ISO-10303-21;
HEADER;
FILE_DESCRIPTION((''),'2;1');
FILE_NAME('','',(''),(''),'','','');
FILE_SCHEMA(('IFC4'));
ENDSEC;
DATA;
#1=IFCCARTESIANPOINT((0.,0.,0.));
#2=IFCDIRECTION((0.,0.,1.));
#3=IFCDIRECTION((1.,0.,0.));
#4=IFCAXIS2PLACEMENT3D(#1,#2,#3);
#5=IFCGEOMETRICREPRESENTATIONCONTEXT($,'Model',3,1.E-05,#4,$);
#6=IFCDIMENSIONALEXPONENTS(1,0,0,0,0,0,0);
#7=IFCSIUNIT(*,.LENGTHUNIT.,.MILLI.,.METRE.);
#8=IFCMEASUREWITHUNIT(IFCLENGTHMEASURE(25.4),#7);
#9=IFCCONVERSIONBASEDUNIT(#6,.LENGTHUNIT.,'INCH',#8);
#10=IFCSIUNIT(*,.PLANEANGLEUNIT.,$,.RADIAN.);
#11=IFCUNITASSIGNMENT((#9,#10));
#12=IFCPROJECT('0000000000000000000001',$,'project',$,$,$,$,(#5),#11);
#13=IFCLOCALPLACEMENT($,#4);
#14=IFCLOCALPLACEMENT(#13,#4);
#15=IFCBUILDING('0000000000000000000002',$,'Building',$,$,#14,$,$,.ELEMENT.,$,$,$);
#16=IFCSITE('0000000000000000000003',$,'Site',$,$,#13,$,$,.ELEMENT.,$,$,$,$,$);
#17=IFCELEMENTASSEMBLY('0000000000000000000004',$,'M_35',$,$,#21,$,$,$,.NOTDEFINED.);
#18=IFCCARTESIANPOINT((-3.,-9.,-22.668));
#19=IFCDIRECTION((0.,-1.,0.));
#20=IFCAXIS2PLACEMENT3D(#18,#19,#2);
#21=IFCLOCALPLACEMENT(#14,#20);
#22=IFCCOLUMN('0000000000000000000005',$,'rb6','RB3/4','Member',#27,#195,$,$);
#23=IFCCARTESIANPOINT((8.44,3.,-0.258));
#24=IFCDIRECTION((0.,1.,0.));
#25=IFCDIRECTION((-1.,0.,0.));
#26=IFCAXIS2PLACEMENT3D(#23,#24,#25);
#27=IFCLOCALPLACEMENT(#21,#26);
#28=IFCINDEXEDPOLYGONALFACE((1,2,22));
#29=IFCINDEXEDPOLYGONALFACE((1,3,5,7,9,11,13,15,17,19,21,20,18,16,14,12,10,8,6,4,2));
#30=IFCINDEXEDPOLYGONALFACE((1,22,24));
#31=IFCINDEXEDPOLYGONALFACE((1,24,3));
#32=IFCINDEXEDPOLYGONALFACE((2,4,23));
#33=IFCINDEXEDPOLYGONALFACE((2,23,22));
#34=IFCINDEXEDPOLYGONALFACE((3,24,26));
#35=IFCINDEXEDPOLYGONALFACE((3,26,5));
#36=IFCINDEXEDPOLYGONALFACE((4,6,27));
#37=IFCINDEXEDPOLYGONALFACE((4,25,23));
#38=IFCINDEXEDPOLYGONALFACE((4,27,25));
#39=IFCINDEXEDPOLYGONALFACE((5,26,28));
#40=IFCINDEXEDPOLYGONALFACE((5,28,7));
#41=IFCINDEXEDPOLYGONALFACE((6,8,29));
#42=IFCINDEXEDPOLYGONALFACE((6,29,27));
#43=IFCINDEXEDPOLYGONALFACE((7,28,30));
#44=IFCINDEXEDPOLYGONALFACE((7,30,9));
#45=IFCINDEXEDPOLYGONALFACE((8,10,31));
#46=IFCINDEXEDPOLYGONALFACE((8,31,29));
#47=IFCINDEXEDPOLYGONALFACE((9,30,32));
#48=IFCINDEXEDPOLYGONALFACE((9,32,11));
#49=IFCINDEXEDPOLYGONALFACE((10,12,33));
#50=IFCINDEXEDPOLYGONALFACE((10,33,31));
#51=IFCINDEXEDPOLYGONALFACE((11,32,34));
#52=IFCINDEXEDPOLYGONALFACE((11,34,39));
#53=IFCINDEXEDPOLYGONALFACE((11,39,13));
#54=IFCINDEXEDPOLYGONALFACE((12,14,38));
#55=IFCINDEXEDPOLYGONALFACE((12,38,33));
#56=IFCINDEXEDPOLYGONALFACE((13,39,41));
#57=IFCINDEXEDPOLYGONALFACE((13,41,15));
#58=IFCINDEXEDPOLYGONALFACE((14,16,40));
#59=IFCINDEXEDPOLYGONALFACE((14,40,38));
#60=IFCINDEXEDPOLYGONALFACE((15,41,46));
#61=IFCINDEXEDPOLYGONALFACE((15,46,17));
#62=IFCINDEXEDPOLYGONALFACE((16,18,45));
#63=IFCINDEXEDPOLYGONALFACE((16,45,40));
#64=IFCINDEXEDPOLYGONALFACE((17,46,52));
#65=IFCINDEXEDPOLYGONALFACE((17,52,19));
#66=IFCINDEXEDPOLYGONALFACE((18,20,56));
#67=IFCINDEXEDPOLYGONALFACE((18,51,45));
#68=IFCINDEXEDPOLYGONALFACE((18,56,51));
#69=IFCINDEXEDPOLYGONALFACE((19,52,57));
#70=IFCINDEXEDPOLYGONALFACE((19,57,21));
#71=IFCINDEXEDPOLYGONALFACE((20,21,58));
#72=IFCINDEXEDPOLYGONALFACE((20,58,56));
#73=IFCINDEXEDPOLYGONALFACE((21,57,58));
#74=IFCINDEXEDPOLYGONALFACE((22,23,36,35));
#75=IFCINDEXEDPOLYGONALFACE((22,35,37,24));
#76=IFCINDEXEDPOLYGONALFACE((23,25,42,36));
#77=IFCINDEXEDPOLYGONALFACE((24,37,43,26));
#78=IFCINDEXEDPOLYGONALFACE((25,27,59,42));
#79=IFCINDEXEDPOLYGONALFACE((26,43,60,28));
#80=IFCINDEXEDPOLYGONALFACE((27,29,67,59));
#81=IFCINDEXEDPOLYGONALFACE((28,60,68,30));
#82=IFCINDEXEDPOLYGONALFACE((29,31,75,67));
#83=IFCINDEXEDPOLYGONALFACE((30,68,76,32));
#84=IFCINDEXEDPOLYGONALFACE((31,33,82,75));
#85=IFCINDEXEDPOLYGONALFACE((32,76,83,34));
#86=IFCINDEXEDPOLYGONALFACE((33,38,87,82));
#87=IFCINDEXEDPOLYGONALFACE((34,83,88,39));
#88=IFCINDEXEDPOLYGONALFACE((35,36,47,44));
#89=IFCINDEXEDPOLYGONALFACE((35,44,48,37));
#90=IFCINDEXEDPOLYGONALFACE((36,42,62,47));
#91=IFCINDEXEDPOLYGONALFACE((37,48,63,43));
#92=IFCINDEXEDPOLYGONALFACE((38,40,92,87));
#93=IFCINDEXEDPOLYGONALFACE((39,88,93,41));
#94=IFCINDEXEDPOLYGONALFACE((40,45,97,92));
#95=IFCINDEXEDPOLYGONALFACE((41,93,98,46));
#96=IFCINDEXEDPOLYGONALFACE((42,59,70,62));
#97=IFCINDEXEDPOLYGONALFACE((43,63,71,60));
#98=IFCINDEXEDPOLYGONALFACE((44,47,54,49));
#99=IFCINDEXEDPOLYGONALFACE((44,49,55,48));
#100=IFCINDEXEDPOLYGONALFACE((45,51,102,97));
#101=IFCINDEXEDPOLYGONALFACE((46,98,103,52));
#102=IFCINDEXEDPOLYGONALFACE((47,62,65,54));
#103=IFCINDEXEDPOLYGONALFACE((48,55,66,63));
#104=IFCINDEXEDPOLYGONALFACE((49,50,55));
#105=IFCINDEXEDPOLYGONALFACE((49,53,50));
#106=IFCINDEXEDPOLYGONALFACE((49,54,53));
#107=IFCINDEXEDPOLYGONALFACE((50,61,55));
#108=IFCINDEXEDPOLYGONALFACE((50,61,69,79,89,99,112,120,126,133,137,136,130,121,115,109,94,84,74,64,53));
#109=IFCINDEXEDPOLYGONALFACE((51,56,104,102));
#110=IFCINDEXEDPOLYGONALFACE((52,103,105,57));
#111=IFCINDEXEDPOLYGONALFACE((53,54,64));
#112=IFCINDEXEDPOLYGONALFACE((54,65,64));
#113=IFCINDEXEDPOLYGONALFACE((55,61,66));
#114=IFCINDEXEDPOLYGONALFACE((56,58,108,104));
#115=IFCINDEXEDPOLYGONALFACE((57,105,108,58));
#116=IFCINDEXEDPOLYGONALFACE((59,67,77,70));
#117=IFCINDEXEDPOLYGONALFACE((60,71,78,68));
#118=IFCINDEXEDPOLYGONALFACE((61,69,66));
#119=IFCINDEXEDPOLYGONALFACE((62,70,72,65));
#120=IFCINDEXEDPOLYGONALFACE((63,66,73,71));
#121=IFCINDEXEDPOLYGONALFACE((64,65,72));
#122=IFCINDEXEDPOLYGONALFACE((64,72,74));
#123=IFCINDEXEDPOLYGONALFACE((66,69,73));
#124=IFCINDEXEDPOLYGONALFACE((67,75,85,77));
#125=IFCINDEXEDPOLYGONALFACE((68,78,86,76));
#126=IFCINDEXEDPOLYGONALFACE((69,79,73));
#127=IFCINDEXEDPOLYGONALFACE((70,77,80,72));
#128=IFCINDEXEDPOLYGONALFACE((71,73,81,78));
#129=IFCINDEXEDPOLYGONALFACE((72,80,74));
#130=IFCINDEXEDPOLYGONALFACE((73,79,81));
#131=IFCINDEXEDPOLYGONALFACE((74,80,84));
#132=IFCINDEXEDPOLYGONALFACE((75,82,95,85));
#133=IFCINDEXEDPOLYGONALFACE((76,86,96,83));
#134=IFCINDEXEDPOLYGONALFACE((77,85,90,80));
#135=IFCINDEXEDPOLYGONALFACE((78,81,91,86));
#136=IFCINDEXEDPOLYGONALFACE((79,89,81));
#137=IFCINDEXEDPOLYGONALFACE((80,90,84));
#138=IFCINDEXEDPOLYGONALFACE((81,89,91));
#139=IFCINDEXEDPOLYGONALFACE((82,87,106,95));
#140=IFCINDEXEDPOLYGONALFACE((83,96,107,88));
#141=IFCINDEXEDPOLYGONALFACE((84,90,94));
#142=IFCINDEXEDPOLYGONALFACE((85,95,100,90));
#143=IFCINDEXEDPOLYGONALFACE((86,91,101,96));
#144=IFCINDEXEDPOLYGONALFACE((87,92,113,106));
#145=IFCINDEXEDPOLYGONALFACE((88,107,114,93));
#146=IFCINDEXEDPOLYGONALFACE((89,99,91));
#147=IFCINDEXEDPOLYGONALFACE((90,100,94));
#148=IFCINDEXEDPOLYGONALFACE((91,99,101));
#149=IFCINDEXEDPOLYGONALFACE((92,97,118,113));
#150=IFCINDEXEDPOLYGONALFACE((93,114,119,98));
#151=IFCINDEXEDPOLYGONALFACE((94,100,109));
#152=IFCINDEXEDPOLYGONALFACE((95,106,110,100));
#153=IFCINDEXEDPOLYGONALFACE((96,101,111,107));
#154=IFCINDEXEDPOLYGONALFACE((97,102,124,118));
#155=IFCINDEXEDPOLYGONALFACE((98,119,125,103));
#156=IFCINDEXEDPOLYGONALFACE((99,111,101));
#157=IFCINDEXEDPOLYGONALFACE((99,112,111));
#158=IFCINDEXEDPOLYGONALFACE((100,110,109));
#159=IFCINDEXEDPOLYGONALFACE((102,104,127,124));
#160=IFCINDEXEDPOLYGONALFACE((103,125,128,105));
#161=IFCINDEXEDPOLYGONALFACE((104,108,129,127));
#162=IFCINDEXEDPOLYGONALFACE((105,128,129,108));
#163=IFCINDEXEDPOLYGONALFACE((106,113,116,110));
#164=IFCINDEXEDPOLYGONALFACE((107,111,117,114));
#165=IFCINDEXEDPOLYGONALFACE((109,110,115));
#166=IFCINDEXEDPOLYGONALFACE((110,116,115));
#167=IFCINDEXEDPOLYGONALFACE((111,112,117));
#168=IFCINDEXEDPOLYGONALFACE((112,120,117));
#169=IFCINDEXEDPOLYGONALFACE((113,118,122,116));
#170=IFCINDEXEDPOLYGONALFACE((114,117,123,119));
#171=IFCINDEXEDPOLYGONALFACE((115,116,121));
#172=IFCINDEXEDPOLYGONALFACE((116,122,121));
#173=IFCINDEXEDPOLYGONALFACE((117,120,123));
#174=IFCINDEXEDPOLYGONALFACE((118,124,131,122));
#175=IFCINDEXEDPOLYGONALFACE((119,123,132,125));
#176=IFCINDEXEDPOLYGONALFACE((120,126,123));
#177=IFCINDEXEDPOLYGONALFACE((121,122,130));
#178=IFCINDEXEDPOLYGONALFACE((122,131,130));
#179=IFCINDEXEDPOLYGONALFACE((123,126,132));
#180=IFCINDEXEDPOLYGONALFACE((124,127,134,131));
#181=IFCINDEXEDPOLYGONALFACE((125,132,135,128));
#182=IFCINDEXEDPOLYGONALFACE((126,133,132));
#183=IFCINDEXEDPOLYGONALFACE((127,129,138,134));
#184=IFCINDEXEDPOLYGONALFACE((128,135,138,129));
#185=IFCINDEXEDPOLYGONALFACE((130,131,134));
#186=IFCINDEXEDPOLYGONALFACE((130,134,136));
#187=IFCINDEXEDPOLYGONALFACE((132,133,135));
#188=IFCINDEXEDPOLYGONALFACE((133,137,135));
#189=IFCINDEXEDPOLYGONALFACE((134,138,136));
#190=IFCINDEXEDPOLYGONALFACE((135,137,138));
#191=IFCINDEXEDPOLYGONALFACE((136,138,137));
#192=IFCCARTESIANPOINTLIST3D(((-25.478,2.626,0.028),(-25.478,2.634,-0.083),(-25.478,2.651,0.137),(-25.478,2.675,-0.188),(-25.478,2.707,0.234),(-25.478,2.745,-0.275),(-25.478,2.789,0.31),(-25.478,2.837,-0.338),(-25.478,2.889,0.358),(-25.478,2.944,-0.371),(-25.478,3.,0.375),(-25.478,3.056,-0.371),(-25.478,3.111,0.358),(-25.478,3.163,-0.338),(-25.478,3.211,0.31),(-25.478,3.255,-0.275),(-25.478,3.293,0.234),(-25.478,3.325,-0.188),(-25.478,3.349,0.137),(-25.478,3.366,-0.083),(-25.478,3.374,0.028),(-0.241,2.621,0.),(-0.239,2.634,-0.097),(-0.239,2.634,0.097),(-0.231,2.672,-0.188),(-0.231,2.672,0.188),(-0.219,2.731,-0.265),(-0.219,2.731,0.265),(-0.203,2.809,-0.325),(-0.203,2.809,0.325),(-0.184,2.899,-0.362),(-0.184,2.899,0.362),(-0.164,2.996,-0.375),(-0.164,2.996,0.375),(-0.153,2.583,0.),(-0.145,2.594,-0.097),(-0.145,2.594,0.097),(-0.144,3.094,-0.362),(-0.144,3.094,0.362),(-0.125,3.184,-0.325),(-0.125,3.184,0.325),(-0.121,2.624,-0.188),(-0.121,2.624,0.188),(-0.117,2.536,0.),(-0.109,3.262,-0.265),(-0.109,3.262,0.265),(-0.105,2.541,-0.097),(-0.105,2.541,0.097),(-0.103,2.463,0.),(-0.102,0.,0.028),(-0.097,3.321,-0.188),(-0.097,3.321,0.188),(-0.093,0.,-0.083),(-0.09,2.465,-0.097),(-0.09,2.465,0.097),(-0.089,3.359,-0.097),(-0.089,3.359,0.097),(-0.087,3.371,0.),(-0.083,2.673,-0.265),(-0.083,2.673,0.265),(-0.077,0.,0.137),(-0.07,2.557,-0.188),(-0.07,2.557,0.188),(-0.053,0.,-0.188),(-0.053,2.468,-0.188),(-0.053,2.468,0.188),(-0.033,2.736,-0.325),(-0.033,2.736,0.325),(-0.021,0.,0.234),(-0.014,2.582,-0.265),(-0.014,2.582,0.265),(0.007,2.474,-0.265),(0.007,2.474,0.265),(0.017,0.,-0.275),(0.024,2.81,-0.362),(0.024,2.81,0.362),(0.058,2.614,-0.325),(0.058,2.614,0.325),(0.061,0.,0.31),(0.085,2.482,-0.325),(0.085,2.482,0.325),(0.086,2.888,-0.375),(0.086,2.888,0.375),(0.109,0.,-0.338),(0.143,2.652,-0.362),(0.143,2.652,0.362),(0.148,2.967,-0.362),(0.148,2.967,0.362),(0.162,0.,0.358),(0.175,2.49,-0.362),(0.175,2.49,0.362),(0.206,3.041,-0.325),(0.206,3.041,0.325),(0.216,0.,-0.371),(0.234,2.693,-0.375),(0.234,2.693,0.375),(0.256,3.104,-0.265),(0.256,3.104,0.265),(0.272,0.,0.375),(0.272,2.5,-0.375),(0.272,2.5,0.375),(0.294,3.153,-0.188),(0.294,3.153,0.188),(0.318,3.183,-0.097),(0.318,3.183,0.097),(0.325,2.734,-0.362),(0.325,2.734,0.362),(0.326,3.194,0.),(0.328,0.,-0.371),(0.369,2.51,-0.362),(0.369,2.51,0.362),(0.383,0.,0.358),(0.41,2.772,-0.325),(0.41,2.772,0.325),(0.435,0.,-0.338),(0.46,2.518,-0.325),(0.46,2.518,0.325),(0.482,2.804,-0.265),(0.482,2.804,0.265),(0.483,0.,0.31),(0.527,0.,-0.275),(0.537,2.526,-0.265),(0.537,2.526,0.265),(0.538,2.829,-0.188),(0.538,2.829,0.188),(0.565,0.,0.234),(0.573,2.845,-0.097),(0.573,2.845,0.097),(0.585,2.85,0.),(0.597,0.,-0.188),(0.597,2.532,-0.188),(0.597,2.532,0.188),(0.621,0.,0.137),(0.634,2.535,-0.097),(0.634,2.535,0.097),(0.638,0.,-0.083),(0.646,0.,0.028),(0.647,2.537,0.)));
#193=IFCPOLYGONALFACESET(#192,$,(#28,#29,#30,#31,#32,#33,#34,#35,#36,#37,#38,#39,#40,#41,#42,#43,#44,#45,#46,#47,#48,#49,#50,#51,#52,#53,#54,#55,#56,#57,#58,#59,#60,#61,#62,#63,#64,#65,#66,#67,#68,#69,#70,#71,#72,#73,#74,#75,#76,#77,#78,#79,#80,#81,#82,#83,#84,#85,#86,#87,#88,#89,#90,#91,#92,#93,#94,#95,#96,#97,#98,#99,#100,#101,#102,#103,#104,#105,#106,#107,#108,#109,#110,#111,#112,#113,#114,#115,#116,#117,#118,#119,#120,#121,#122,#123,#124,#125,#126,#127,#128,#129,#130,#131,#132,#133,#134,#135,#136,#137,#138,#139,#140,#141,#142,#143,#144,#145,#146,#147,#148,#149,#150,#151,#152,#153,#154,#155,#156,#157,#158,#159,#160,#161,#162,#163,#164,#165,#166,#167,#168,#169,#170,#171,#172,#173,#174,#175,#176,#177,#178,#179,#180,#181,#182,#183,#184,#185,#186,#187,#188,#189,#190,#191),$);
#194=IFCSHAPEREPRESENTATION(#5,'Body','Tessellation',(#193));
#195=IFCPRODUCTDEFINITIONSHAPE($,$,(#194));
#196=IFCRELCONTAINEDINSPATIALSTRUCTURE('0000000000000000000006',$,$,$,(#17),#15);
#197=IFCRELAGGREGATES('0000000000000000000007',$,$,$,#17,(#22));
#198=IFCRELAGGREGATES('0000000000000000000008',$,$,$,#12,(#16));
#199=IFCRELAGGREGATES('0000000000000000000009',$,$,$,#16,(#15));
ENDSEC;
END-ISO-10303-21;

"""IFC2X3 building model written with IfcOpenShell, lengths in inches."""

from ifc_helpers import new_model, entity, si_unit, converted_unit, frame, origin_with_axes, place, context, project, spatial, element, aggregate, save


model = new_model("IFC2X3")

# Units and contexts
model_context = context("Model", 3, precision=1e-05, world=origin_with_axes())
ifc_project = project(units=[converted_unit("LENGTHUNIT", "INCH", entity("IfcLengthMeasure", 25.4), si_unit("LENGTHUNIT", "METRE", prefix="MILLI"), dimensions=[1, 0, 0, 0, 0, 0, 0]), si_unit("PLANEANGLEUNIT", "RADIAN")], contexts=[model_context])

# Site, building
site_placement = place(None, origin_with_axes())
site = spatial("IfcSite", under=ifc_project, at=site_placement, Name="Site", CompositionType="ELEMENT")
building_placement = place(site_placement, origin_with_axes())
building = spatial("IfcBuilding", under=site, at=building_placement, Name="Building", CompositionType="ELEMENT")

# Element assembly, column
assembly_1_placement = place(building_placement, frame((-3.0, -9.0, -22.668), z_axis=(0.0, -1.0, 0.0), x_axis=(0.0, 0.0, 1.0)))
assembly_1 = element("IfcElementAssembly", 1, at=assembly_1_placement, inside=building, Name="M_35", PredefinedType="NOTDEFINED")
column_1_placement = place(assembly_1_placement, frame((8.44, 3.0, -0.258), z_axis=(0.0, 1.0, 0.0), x_axis=(-1.0, 0.0, 0.0)))
cartesian_point_1 = entity("IfcCartesianPoint", [0.0, 0.0, 0.0])
ifc_direction_1 = entity("IfcDirection", [0.0, 0.0, 1.0])
ifc_direction_2 = entity("IfcDirection", [1.0, 0.0, 0.0])
column_1 = element("IfcColumn", 2, at=column_1_placement, Name="rb6", Description="RB3/4", ObjectType="Member", context=model_context, shape_type="SweptSolid", body=[
    entity("IfcSurfaceCurveSweptAreaSolid", entity("IfcCircleProfileDef", "AREA", None, entity("IfcAxis2Placement2D", entity("IfcCartesianPoint", [0.0, 0.0]), entity("IfcDirection", [1.0, 0.0])), 0.375), entity("IfcAxis2Placement3D", cartesian_point_1, ifc_direction_1, ifc_direction_2), entity("IfcPolyline", [entity("IfcCartesianPoint", [0.272, 0.0]), entity("IfcCartesianPoint", [0.272, 2.5]), entity("IfcCartesianPoint", [0.234, 2.693]), entity("IfcCartesianPoint", [0.086, 2.888]), entity("IfcCartesianPoint", [-0.164, 2.996]), entity("IfcCartesianPoint", [-25.478, 3.0])]), 0.0, 1.0, entity("IfcPlane", entity("IfcAxis2Placement3D", cartesian_point_1, ifc_direction_1, ifc_direction_2))),
])
aggregate(assembly_1, [column_1])

save(model, "model.ifc")
